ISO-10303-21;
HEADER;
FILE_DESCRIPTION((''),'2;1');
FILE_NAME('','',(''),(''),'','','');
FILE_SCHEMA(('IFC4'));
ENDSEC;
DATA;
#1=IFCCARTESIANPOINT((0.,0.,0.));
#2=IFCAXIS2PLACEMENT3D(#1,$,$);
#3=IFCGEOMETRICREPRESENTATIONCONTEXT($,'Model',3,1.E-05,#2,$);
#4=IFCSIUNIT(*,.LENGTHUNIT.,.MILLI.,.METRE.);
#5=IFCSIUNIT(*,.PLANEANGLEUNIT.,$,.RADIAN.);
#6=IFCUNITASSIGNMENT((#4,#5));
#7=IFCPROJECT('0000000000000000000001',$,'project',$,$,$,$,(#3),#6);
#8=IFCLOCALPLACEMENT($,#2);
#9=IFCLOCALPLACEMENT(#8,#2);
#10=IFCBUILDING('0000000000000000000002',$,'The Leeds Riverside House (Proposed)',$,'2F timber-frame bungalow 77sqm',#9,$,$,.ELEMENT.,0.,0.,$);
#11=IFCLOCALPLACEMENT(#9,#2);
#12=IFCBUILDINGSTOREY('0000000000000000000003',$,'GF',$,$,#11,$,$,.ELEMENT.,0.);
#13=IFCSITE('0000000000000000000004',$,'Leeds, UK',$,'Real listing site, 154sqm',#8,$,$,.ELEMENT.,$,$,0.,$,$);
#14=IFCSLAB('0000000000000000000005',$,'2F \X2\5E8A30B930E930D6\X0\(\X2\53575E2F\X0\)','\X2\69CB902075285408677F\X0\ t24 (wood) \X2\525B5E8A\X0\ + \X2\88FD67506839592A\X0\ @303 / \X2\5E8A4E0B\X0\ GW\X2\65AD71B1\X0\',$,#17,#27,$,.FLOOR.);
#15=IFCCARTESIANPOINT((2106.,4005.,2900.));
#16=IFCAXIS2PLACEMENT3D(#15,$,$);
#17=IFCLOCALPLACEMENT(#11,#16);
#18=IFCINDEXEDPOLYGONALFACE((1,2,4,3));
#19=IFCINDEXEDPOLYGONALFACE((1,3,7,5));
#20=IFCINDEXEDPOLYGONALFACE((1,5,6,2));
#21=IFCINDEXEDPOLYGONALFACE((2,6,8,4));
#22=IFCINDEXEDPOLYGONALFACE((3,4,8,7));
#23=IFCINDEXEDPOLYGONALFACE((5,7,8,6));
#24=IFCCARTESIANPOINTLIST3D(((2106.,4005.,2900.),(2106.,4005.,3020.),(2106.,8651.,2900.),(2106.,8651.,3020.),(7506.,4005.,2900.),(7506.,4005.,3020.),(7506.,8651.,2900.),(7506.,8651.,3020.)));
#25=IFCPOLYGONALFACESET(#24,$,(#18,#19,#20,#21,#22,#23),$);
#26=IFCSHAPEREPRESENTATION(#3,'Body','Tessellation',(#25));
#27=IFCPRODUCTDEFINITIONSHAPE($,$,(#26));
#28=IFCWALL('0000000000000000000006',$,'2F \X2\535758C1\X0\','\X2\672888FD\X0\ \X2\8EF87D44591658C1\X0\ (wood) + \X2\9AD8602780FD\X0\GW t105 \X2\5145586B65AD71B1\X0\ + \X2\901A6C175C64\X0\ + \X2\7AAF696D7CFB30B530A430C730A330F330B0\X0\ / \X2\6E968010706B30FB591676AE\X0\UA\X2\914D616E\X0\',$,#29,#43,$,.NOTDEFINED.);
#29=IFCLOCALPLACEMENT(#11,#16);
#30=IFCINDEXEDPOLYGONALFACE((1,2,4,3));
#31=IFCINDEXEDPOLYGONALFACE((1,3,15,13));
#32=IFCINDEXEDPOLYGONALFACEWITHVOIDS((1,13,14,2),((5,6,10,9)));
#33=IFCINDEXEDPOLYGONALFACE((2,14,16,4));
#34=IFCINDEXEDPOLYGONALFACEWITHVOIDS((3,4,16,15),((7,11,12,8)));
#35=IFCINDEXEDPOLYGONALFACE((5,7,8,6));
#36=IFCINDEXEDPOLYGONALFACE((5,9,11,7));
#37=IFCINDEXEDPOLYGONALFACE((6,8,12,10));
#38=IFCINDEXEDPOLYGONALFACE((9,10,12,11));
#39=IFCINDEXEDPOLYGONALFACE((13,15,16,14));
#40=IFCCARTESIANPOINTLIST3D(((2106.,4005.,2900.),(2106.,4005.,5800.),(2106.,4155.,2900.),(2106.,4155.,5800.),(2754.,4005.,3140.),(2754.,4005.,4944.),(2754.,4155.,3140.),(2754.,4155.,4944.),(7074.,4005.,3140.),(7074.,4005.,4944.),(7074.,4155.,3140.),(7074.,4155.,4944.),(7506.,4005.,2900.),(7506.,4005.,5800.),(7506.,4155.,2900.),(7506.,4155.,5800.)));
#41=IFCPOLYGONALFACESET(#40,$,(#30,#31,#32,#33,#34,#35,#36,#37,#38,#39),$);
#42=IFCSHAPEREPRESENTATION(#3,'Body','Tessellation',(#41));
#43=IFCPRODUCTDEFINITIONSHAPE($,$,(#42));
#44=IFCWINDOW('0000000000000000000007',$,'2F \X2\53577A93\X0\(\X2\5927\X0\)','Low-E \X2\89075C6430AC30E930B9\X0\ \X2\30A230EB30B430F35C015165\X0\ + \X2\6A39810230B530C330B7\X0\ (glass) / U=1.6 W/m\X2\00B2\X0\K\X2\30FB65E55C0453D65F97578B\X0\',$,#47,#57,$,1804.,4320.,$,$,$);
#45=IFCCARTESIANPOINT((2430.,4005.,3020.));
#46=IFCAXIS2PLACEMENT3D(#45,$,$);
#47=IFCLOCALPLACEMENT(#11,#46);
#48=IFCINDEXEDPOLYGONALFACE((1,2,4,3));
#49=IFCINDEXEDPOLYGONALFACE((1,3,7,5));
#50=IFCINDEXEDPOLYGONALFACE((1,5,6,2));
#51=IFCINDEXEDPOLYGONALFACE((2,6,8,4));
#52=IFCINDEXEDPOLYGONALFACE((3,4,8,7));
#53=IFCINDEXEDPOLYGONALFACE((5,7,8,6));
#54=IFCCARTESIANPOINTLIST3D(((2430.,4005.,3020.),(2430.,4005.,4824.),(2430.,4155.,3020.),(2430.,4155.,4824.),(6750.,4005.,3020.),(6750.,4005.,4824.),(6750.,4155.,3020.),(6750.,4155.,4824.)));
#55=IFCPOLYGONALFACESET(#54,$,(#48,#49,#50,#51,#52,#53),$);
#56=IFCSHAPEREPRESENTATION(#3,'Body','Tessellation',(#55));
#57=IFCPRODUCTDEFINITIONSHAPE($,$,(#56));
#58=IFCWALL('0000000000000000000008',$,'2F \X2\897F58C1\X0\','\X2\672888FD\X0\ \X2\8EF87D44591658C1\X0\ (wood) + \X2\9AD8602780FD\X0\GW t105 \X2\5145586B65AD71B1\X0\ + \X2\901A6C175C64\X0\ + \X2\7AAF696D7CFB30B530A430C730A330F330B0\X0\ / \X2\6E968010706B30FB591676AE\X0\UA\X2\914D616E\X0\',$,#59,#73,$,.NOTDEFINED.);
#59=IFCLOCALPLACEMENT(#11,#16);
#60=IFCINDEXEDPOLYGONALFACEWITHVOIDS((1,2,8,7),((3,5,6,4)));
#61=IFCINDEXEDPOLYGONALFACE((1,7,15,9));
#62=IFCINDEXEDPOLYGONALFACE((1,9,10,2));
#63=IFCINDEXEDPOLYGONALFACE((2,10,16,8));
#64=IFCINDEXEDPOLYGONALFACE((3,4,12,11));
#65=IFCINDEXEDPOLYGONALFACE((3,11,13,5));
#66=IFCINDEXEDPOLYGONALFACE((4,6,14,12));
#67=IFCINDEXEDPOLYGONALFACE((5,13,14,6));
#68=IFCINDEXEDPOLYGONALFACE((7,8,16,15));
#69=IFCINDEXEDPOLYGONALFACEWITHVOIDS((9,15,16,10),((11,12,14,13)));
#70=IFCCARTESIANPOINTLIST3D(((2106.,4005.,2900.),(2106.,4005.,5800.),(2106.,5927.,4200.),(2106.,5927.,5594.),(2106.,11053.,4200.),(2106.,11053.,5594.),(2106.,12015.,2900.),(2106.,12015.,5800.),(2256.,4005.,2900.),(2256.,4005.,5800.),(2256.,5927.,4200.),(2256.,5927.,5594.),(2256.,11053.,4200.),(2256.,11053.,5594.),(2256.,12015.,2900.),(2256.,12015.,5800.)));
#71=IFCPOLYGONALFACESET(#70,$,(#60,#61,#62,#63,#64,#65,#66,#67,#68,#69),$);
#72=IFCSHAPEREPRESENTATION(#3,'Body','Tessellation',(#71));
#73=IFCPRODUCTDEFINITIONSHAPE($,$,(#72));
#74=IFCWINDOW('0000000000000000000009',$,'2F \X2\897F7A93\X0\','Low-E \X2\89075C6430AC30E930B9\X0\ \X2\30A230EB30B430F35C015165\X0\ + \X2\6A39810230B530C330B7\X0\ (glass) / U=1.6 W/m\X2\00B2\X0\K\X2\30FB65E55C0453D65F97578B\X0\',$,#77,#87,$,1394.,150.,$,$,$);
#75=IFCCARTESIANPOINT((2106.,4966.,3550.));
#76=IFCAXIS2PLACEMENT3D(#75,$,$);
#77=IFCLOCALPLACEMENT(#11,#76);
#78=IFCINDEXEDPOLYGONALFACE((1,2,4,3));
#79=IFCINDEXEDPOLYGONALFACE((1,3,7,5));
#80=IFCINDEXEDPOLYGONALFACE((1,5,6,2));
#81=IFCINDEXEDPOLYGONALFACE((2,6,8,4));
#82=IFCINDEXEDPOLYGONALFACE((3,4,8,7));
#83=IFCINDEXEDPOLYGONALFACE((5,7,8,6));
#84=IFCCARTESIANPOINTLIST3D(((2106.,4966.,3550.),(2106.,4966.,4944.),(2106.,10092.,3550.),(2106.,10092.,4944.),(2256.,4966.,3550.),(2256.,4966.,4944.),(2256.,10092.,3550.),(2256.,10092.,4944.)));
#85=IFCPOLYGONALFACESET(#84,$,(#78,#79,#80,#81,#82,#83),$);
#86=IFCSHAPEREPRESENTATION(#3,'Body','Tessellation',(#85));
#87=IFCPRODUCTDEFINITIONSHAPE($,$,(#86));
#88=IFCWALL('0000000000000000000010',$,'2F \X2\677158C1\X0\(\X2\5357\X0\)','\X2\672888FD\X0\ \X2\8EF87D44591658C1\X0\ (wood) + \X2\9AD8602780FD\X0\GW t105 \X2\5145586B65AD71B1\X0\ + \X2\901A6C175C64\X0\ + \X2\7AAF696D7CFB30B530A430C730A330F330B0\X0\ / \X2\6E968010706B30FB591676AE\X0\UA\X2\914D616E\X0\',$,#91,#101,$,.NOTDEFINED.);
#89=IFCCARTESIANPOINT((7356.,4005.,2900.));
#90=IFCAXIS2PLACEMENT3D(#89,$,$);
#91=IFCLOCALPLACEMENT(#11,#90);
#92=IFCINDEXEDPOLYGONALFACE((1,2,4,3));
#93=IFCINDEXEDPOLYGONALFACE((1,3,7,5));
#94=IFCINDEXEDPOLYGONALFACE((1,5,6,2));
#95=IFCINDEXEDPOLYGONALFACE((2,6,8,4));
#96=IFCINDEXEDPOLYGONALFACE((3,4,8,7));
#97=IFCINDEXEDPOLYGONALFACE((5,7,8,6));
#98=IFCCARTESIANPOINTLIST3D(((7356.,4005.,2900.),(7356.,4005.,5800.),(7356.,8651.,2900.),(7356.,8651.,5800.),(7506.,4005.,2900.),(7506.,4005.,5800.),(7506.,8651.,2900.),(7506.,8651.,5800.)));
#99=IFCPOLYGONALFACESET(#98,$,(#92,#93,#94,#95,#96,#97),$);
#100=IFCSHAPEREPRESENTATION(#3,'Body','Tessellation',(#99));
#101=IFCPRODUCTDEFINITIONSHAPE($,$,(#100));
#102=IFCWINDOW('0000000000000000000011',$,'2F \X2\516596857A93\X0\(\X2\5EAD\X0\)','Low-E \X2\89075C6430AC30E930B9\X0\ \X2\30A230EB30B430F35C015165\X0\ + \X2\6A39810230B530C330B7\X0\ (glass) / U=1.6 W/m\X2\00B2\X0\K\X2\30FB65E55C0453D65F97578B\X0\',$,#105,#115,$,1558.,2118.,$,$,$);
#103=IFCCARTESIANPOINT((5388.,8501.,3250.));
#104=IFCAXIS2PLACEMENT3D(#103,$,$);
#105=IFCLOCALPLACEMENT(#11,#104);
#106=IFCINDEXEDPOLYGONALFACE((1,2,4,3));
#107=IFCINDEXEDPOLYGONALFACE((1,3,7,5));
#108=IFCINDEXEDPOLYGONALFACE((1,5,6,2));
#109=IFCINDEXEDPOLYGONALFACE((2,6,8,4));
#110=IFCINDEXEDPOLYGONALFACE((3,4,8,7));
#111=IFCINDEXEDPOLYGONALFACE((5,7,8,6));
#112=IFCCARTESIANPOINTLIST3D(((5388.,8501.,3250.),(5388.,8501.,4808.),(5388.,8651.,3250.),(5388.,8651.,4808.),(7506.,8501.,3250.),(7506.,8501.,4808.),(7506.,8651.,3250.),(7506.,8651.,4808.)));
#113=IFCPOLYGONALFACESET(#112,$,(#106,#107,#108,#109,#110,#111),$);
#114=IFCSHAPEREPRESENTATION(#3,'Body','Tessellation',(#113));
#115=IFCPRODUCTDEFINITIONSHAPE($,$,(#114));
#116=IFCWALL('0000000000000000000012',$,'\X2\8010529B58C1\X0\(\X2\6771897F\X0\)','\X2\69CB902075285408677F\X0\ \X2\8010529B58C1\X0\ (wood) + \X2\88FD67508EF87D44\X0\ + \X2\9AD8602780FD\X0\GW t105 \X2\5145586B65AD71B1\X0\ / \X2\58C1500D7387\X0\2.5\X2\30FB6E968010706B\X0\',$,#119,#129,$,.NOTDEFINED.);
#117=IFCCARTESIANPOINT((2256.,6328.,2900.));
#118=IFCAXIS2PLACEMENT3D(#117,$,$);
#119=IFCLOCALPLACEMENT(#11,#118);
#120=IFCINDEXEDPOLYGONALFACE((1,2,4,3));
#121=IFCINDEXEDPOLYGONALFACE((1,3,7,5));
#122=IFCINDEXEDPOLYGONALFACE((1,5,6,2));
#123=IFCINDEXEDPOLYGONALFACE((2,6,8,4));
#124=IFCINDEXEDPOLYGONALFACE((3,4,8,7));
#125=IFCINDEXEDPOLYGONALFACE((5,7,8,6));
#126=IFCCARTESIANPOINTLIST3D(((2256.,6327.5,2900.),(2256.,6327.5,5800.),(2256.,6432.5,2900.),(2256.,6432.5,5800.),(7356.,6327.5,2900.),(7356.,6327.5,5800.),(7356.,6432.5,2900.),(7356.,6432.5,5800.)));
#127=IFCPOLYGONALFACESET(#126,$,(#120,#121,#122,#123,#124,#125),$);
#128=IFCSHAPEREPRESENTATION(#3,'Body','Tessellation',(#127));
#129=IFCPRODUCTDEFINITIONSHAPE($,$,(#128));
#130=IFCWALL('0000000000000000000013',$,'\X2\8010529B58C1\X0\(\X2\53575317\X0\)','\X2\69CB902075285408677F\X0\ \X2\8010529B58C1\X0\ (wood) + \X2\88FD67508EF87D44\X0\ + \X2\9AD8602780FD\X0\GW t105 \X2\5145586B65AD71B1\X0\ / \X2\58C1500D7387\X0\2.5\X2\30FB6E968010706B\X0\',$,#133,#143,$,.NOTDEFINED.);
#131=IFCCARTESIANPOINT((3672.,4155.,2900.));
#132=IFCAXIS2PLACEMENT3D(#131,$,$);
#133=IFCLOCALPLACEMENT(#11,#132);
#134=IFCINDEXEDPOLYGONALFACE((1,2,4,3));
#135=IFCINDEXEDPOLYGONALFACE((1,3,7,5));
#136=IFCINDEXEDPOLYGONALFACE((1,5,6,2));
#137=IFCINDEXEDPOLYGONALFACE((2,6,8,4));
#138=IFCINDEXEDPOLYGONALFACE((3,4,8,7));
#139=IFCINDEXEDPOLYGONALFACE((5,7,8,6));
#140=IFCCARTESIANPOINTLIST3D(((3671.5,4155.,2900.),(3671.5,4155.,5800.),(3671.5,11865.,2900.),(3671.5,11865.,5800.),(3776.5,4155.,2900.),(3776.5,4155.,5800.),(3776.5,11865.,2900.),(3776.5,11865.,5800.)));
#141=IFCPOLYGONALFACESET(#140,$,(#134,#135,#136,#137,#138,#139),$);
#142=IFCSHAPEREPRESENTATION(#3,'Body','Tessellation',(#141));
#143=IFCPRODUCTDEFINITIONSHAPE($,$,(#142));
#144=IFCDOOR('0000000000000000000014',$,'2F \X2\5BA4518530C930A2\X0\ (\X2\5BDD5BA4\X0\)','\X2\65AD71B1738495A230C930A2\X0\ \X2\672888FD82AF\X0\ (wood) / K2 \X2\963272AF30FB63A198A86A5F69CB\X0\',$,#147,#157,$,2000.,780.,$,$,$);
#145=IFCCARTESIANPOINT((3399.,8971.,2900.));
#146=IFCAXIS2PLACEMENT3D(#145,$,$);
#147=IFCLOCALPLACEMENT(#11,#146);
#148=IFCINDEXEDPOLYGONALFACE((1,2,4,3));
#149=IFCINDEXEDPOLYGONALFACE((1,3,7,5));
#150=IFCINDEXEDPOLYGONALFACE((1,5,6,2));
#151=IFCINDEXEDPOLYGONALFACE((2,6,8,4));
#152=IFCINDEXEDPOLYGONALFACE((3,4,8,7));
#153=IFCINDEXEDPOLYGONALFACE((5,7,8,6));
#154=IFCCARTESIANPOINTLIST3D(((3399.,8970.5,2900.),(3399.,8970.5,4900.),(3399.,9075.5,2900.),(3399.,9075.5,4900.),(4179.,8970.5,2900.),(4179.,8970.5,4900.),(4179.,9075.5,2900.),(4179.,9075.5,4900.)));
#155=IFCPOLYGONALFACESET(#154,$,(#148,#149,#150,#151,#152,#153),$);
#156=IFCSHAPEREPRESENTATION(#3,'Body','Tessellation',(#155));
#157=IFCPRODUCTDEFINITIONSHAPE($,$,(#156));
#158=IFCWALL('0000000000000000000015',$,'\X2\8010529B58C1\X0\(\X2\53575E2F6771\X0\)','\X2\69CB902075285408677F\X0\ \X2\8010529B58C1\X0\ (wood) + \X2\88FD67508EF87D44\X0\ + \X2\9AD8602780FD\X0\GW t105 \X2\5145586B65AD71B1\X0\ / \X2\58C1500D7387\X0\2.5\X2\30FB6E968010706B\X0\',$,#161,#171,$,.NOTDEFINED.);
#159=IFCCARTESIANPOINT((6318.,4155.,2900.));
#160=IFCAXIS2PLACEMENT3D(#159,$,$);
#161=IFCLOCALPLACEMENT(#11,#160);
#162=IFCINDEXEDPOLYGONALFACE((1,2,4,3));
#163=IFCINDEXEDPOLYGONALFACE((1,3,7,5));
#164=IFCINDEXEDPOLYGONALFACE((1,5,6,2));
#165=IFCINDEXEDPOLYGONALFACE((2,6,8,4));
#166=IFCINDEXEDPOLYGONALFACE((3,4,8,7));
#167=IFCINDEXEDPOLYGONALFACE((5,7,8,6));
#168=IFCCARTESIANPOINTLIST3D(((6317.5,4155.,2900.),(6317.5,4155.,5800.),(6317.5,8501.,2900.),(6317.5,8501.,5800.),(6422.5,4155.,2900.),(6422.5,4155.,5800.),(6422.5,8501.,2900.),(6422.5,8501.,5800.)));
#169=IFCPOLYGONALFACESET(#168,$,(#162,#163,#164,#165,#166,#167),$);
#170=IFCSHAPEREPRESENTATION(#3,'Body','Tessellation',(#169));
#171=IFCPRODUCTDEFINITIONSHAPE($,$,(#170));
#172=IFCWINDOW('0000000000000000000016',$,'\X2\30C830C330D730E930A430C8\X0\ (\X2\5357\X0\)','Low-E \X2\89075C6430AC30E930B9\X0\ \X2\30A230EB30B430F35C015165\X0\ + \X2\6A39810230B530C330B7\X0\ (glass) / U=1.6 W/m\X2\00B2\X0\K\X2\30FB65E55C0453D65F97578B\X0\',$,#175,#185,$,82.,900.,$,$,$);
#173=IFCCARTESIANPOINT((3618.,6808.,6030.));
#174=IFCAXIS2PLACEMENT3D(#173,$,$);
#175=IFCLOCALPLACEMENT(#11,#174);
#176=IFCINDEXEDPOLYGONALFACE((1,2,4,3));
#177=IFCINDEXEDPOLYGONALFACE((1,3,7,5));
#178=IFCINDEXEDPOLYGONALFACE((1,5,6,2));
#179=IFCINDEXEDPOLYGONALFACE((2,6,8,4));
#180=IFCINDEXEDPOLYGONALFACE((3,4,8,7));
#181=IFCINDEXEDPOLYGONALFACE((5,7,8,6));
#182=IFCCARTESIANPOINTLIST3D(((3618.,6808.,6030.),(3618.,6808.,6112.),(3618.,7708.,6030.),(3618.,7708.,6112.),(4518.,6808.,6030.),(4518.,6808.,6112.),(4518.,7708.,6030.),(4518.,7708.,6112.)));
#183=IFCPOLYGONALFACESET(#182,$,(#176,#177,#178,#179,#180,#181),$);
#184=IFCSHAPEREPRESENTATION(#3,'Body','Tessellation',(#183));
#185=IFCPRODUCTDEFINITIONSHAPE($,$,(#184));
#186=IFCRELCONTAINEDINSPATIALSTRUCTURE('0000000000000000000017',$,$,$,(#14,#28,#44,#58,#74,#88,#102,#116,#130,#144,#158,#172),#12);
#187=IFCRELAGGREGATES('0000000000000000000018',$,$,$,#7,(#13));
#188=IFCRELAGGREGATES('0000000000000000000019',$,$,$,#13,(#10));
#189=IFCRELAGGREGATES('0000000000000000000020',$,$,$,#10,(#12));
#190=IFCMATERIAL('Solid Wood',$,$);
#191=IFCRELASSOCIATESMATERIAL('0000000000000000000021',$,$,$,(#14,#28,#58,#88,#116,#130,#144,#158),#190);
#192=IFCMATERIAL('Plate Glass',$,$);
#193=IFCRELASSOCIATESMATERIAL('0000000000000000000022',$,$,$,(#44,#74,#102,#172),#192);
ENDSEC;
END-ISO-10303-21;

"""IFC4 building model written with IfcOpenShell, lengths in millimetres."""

from ifc_helpers import new_model, si_unit, frame, frame_2d, origin, place, context, project, spatial, rectangle, extrude, material, element, fill, save


model = new_model("IFC4")

# Units and contexts
model_context = context("Model", 3, precision=1e-05, world=origin())
ifc_project = project(units=[si_unit("LENGTHUNIT", "METRE", prefix="MILLI"), si_unit("PLANEANGLEUNIT", "RADIAN")], contexts=[model_context])

# Site, building, storey
site_placement = place(None, origin())
site = spatial("IfcSite", under=ifc_project, at=site_placement, Name="Leeds, UK", ObjectType="Real listing site, 154sqm", CompositionType="ELEMENT", RefElevation=0.0)
building_placement = place(site_placement, origin())
building = spatial("IfcBuilding", under=site, at=building_placement, Name="The Leeds Riverside House (Proposed)", ObjectType="2F timber-frame bungalow 77sqm", CompositionType="ELEMENT", ElevationOfRefHeight=0.0, ElevationOfTerrain=0.0)
storey_placement = place(building_placement, origin())
storey = spatial("IfcBuildingStorey", under=building, at=storey_placement, Name="GF", CompositionType="ELEMENT", Elevation=0.0)

# Slab
ifc_material_1 = material(Name="Solid Wood")
slab_placement = place(storey_placement, frame((2106.0, 4005.0, 2900.0)))
element("IfcSlab", 1, at=slab_placement, inside=storey, material=ifc_material_1, Name="2F 床スラブ(南帯)", Description="構造用合板 t24 (wood) 剛床 + 製材根太 @303 / 床下 GW断熱", PredefinedType="FLOOR", context=model_context, shape_type="SweptSolid", body=[
    extrude(rectangle(XDim=5400.0, YDim=4646.0, at=frame_2d((2700.0, 2323.0))), frame((2106.0, 4005.0, 2900.0)), (0.0, 0.0, 1.0), 120.0),
])

# Walls, openings, windows
wall_1_placement = place(storey_placement, frame((2106.0, 4005.0, 2900.0)))
wall_1 = element("IfcWall", 2, at=wall_1_placement, inside=storey, material=ifc_material_1, Name="2F 南壁", Description="木製 軸組外壁 (wood) + 高性能GW t105 充填断熱 + 通気層 + 窯業系サイディング / 準耐火・外皮UA配慮", PredefinedType="NOTDEFINED", context=model_context, shape_type="SweptSolid", body=[
    extrude(rectangle(XDim=5400.0, YDim=150.0, at=frame_2d((2700.0, 75.0))), frame((2106.0, 4005.0, 2900.0)), (0.0, 0.0, 1.0), 2900.0),
])
opening_1_placement = place(storey_placement, frame((2430.0, 4005.0, 3020.0)))
opening_1 = element("IfcOpeningElement", 3, at=opening_1_placement, cuts=wall_1, PredefinedType="NOTDEFINED", context=model_context, shape_type="SweptSolid", body=[
    extrude(rectangle(XDim=4320.0, YDim=150.0, at=frame_2d((2160.0, 75.0))), frame((2430.0, 4005.0, 3020.0)), (0.0, 0.0, 1.0), 1804.0),
])
ifc_material_2 = material(Name="Plate Glass")
window_1_placement = place(storey_placement, frame((2430.0, 4005.0, 3020.0)))
window_1 = element("IfcWindow", 4, at=window_1_placement, inside=storey, material=ifc_material_2, Name="2F 南窓(大)", Description="Low-E 複層ガラス アルゴン封入 + 樹脂サッシ (glass) / U=1.6 W/m²K・日射取得型", OverallHeight=1804.0, OverallWidth=4320.0, context=model_context, shape_type="SweptSolid", body=[
    extrude(rectangle(XDim=4320.0, YDim=150.0, at=frame_2d((2160.0, 75.0))), frame((2430.0, 4005.0, 3020.0)), (0.0, 0.0, 1.0), 1804.0),
])
fill(opening_1, window_1)
wall_2_placement = place(storey_placement, frame((2106.0, 4005.0, 2900.0)))
wall_2 = element("IfcWall", 5, at=wall_2_placement, inside=storey, material=ifc_material_1, Name="2F 西壁", Description="木製 軸組外壁 (wood) + 高性能GW t105 充填断熱 + 通気層 + 窯業系サイディング / 準耐火・外皮UA配慮", PredefinedType="NOTDEFINED", context=model_context, shape_type="SweptSolid", body=[
    extrude(rectangle(XDim=150.0, YDim=8010.0, at=frame_2d((75.0, 4005.0))), frame((2106.0, 4005.0, 2900.0)), (0.0, 0.0, 1.0), 2900.0),
])
opening_2_placement = place(storey_placement, frame((2106.0, 4966.0, 3550.0)))
opening_2 = element("IfcOpeningElement", 6, at=opening_2_placement, cuts=wall_2, PredefinedType="NOTDEFINED", context=model_context, shape_type="SweptSolid", body=[
    extrude(rectangle(XDim=150.0, YDim=5126.0, at=frame_2d((75.0, 2563.0))), frame((2106.0, 4966.0, 3550.0)), (0.0, 0.0, 1.0), 1394.0),
])
window_2_placement = place(storey_placement, frame((2106.0, 4966.0, 3550.0)))
window_2 = element("IfcWindow", 7, at=window_2_placement, inside=storey, material=ifc_material_2, Name="2F 西窓", Description="Low-E 複層ガラス アルゴン封入 + 樹脂サッシ (glass) / U=1.6 W/m²K・日射取得型", OverallHeight=1394.0, OverallWidth=150.0, context=model_context, shape_type="SweptSolid", body=[
    extrude(rectangle(XDim=150.0, YDim=5126.0, at=frame_2d((75.0, 2563.0))), frame((2106.0, 4966.0, 3550.0)), (0.0, 0.0, 1.0), 1394.0),
])
fill(opening_2, window_2)
wall_3_placement = place(storey_placement, frame((7356.0, 4005.0, 2900.0)))
wall_3 = element("IfcWall", 8, at=wall_3_placement, inside=storey, material=ifc_material_1, Name="2F 東壁(南)", Description="木製 軸組外壁 (wood) + 高性能GW t105 充填断熱 + 通気層 + 窯業系サイディング / 準耐火・外皮UA配慮", PredefinedType="NOTDEFINED", context=model_context, shape_type="SweptSolid", body=[
    extrude(rectangle(XDim=150.0, YDim=4646.0, at=frame_2d((75.0, 2323.0))), frame((7356.0, 4005.0, 2900.0)), (0.0, 0.0, 1.0), 2900.0),
])
opening_3_placement = place(storey_placement, frame((5388.0, 8501.0, 3250.0)))
opening_3 = element("IfcOpeningElement", 9, at=opening_3_placement, cuts=wall_3, PredefinedType="NOTDEFINED", context=model_context, shape_type="SweptSolid", body=[
    extrude(rectangle(XDim=2118.0, YDim=150.0, at=frame_2d((1059.0, 75.0))), frame((5388.0, 8501.0, 3250.0)), (0.0, 0.0, 1.0), 1558.0),
])
window_3_placement = place(storey_placement, frame((5388.0, 8501.0, 3250.0)))
window_3 = element("IfcWindow", 10, at=window_3_placement, inside=storey, material=ifc_material_2, Name="2F 入隅窓(庭)", Description="Low-E 複層ガラス アルゴン封入 + 樹脂サッシ (glass) / U=1.6 W/m²K・日射取得型", OverallHeight=1558.0, OverallWidth=2118.0, context=model_context, shape_type="SweptSolid", body=[
    extrude(rectangle(XDim=2118.0, YDim=150.0, at=frame_2d((1059.0, 75.0))), frame((5388.0, 8501.0, 3250.0)), (0.0, 0.0, 1.0), 1558.0),
])
fill(opening_3, window_3)

# Wall
wall_4_placement = place(storey_placement, frame((2256.0, 6328.0, 2900.0)))
element("IfcWall", 11, at=wall_4_placement, inside=storey, material=ifc_material_1, Name="耐力壁(東西)", Description="構造用合板 耐力壁 (wood) + 製材軸組 + 高性能GW t105 充填断熱 / 壁倍率2.5・準耐火", PredefinedType="NOTDEFINED", context=model_context, shape_type="SweptSolid", body=[
    extrude(rectangle(XDim=5100.0, YDim=105.0, at=frame_2d((2550.0, 52.0))), frame((2256.0, 6328.0, 2900.0)), (0.0, 0.0, 1.0), 2900.0),
])

# Wall, opening, door
wall_5_placement = place(storey_placement, frame((3672.0, 4155.0, 2900.0)))
wall_5 = element("IfcWall", 12, at=wall_5_placement, inside=storey, material=ifc_material_1, Name="耐力壁(南北)", Description="構造用合板 耐力壁 (wood) + 製材軸組 + 高性能GW t105 充填断熱 / 壁倍率2.5・準耐火", PredefinedType="NOTDEFINED", context=model_context, shape_type="SweptSolid", body=[
    extrude(rectangle(XDim=105.0, YDim=7710.0, at=frame_2d((52.0, 3855.0))), frame((3672.0, 4155.0, 2900.0)), (0.0, 0.0, 1.0), 2900.0),
])
opening_4_placement = place(storey_placement, frame((3399.0, 8971.0, 2900.0)))
opening_4 = element("IfcOpeningElement", 13, at=opening_4_placement, cuts=wall_5, PredefinedType="NOTDEFINED", context=model_context, shape_type="SweptSolid", body=[
    extrude(rectangle(XDim=780.0, YDim=105.0, at=frame_2d((390.0, 52.0))), frame((3399.0, 8971.0, 2900.0)), (0.0, 0.0, 1.0), 2000.0),
])
door_placement = place(storey_placement, frame((3399.0, 8971.0, 2900.0)))
door = element("IfcDoor", 14, at=door_placement, inside=storey, material=ifc_material_1, Name="2F 室内ドア (寝室)", Description="断熱玄関ドア 木製芯 (wood) / K2 防犯・採風機構", OverallHeight=2000.0, OverallWidth=780.0, context=model_context, shape_type="SweptSolid", body=[
    extrude(rectangle(XDim=780.0, YDim=105.0, at=frame_2d((390.0, 52.0))), frame((3399.0, 8971.0, 2900.0)), (0.0, 0.0, 1.0), 2000.0),
])
fill(opening_4, door)

# Wall
wall_6_placement = place(storey_placement, frame((6318.0, 4155.0, 2900.0)))
element("IfcWall", 15, at=wall_6_placement, inside=storey, material=ifc_material_1, Name="耐力壁(南帯東)", Description="構造用合板 耐力壁 (wood) + 製材軸組 + 高性能GW t105 充填断熱 / 壁倍率2.5・準耐火", PredefinedType="NOTDEFINED", context=model_context, shape_type="SweptSolid", body=[
    extrude(rectangle(XDim=105.0, YDim=4346.0, at=frame_2d((52.0, 2173.0))), frame((6318.0, 4155.0, 2900.0)), (0.0, 0.0, 1.0), 2900.0),
])

# Window
window_4_placement = place(storey_placement, frame((3618.0, 6808.0, 6030.0)))
element("IfcWindow", 16, at=window_4_placement, inside=storey, material=ifc_material_2, Name="トップライト (南)", Description="Low-E 複層ガラス アルゴン封入 + 樹脂サッシ (glass) / U=1.6 W/m²K・日射取得型", OverallHeight=82.0, OverallWidth=900.0, context=model_context, shape_type="SweptSolid", body=[
    extrude(rectangle(XDim=900.0, YDim=900.0, at=frame_2d((450.0, 450.0))), frame((3618.0, 6808.0, 6030.0)), (0.0, 0.0, 1.0), 82.0),
])

save(model, "model.ifc")
